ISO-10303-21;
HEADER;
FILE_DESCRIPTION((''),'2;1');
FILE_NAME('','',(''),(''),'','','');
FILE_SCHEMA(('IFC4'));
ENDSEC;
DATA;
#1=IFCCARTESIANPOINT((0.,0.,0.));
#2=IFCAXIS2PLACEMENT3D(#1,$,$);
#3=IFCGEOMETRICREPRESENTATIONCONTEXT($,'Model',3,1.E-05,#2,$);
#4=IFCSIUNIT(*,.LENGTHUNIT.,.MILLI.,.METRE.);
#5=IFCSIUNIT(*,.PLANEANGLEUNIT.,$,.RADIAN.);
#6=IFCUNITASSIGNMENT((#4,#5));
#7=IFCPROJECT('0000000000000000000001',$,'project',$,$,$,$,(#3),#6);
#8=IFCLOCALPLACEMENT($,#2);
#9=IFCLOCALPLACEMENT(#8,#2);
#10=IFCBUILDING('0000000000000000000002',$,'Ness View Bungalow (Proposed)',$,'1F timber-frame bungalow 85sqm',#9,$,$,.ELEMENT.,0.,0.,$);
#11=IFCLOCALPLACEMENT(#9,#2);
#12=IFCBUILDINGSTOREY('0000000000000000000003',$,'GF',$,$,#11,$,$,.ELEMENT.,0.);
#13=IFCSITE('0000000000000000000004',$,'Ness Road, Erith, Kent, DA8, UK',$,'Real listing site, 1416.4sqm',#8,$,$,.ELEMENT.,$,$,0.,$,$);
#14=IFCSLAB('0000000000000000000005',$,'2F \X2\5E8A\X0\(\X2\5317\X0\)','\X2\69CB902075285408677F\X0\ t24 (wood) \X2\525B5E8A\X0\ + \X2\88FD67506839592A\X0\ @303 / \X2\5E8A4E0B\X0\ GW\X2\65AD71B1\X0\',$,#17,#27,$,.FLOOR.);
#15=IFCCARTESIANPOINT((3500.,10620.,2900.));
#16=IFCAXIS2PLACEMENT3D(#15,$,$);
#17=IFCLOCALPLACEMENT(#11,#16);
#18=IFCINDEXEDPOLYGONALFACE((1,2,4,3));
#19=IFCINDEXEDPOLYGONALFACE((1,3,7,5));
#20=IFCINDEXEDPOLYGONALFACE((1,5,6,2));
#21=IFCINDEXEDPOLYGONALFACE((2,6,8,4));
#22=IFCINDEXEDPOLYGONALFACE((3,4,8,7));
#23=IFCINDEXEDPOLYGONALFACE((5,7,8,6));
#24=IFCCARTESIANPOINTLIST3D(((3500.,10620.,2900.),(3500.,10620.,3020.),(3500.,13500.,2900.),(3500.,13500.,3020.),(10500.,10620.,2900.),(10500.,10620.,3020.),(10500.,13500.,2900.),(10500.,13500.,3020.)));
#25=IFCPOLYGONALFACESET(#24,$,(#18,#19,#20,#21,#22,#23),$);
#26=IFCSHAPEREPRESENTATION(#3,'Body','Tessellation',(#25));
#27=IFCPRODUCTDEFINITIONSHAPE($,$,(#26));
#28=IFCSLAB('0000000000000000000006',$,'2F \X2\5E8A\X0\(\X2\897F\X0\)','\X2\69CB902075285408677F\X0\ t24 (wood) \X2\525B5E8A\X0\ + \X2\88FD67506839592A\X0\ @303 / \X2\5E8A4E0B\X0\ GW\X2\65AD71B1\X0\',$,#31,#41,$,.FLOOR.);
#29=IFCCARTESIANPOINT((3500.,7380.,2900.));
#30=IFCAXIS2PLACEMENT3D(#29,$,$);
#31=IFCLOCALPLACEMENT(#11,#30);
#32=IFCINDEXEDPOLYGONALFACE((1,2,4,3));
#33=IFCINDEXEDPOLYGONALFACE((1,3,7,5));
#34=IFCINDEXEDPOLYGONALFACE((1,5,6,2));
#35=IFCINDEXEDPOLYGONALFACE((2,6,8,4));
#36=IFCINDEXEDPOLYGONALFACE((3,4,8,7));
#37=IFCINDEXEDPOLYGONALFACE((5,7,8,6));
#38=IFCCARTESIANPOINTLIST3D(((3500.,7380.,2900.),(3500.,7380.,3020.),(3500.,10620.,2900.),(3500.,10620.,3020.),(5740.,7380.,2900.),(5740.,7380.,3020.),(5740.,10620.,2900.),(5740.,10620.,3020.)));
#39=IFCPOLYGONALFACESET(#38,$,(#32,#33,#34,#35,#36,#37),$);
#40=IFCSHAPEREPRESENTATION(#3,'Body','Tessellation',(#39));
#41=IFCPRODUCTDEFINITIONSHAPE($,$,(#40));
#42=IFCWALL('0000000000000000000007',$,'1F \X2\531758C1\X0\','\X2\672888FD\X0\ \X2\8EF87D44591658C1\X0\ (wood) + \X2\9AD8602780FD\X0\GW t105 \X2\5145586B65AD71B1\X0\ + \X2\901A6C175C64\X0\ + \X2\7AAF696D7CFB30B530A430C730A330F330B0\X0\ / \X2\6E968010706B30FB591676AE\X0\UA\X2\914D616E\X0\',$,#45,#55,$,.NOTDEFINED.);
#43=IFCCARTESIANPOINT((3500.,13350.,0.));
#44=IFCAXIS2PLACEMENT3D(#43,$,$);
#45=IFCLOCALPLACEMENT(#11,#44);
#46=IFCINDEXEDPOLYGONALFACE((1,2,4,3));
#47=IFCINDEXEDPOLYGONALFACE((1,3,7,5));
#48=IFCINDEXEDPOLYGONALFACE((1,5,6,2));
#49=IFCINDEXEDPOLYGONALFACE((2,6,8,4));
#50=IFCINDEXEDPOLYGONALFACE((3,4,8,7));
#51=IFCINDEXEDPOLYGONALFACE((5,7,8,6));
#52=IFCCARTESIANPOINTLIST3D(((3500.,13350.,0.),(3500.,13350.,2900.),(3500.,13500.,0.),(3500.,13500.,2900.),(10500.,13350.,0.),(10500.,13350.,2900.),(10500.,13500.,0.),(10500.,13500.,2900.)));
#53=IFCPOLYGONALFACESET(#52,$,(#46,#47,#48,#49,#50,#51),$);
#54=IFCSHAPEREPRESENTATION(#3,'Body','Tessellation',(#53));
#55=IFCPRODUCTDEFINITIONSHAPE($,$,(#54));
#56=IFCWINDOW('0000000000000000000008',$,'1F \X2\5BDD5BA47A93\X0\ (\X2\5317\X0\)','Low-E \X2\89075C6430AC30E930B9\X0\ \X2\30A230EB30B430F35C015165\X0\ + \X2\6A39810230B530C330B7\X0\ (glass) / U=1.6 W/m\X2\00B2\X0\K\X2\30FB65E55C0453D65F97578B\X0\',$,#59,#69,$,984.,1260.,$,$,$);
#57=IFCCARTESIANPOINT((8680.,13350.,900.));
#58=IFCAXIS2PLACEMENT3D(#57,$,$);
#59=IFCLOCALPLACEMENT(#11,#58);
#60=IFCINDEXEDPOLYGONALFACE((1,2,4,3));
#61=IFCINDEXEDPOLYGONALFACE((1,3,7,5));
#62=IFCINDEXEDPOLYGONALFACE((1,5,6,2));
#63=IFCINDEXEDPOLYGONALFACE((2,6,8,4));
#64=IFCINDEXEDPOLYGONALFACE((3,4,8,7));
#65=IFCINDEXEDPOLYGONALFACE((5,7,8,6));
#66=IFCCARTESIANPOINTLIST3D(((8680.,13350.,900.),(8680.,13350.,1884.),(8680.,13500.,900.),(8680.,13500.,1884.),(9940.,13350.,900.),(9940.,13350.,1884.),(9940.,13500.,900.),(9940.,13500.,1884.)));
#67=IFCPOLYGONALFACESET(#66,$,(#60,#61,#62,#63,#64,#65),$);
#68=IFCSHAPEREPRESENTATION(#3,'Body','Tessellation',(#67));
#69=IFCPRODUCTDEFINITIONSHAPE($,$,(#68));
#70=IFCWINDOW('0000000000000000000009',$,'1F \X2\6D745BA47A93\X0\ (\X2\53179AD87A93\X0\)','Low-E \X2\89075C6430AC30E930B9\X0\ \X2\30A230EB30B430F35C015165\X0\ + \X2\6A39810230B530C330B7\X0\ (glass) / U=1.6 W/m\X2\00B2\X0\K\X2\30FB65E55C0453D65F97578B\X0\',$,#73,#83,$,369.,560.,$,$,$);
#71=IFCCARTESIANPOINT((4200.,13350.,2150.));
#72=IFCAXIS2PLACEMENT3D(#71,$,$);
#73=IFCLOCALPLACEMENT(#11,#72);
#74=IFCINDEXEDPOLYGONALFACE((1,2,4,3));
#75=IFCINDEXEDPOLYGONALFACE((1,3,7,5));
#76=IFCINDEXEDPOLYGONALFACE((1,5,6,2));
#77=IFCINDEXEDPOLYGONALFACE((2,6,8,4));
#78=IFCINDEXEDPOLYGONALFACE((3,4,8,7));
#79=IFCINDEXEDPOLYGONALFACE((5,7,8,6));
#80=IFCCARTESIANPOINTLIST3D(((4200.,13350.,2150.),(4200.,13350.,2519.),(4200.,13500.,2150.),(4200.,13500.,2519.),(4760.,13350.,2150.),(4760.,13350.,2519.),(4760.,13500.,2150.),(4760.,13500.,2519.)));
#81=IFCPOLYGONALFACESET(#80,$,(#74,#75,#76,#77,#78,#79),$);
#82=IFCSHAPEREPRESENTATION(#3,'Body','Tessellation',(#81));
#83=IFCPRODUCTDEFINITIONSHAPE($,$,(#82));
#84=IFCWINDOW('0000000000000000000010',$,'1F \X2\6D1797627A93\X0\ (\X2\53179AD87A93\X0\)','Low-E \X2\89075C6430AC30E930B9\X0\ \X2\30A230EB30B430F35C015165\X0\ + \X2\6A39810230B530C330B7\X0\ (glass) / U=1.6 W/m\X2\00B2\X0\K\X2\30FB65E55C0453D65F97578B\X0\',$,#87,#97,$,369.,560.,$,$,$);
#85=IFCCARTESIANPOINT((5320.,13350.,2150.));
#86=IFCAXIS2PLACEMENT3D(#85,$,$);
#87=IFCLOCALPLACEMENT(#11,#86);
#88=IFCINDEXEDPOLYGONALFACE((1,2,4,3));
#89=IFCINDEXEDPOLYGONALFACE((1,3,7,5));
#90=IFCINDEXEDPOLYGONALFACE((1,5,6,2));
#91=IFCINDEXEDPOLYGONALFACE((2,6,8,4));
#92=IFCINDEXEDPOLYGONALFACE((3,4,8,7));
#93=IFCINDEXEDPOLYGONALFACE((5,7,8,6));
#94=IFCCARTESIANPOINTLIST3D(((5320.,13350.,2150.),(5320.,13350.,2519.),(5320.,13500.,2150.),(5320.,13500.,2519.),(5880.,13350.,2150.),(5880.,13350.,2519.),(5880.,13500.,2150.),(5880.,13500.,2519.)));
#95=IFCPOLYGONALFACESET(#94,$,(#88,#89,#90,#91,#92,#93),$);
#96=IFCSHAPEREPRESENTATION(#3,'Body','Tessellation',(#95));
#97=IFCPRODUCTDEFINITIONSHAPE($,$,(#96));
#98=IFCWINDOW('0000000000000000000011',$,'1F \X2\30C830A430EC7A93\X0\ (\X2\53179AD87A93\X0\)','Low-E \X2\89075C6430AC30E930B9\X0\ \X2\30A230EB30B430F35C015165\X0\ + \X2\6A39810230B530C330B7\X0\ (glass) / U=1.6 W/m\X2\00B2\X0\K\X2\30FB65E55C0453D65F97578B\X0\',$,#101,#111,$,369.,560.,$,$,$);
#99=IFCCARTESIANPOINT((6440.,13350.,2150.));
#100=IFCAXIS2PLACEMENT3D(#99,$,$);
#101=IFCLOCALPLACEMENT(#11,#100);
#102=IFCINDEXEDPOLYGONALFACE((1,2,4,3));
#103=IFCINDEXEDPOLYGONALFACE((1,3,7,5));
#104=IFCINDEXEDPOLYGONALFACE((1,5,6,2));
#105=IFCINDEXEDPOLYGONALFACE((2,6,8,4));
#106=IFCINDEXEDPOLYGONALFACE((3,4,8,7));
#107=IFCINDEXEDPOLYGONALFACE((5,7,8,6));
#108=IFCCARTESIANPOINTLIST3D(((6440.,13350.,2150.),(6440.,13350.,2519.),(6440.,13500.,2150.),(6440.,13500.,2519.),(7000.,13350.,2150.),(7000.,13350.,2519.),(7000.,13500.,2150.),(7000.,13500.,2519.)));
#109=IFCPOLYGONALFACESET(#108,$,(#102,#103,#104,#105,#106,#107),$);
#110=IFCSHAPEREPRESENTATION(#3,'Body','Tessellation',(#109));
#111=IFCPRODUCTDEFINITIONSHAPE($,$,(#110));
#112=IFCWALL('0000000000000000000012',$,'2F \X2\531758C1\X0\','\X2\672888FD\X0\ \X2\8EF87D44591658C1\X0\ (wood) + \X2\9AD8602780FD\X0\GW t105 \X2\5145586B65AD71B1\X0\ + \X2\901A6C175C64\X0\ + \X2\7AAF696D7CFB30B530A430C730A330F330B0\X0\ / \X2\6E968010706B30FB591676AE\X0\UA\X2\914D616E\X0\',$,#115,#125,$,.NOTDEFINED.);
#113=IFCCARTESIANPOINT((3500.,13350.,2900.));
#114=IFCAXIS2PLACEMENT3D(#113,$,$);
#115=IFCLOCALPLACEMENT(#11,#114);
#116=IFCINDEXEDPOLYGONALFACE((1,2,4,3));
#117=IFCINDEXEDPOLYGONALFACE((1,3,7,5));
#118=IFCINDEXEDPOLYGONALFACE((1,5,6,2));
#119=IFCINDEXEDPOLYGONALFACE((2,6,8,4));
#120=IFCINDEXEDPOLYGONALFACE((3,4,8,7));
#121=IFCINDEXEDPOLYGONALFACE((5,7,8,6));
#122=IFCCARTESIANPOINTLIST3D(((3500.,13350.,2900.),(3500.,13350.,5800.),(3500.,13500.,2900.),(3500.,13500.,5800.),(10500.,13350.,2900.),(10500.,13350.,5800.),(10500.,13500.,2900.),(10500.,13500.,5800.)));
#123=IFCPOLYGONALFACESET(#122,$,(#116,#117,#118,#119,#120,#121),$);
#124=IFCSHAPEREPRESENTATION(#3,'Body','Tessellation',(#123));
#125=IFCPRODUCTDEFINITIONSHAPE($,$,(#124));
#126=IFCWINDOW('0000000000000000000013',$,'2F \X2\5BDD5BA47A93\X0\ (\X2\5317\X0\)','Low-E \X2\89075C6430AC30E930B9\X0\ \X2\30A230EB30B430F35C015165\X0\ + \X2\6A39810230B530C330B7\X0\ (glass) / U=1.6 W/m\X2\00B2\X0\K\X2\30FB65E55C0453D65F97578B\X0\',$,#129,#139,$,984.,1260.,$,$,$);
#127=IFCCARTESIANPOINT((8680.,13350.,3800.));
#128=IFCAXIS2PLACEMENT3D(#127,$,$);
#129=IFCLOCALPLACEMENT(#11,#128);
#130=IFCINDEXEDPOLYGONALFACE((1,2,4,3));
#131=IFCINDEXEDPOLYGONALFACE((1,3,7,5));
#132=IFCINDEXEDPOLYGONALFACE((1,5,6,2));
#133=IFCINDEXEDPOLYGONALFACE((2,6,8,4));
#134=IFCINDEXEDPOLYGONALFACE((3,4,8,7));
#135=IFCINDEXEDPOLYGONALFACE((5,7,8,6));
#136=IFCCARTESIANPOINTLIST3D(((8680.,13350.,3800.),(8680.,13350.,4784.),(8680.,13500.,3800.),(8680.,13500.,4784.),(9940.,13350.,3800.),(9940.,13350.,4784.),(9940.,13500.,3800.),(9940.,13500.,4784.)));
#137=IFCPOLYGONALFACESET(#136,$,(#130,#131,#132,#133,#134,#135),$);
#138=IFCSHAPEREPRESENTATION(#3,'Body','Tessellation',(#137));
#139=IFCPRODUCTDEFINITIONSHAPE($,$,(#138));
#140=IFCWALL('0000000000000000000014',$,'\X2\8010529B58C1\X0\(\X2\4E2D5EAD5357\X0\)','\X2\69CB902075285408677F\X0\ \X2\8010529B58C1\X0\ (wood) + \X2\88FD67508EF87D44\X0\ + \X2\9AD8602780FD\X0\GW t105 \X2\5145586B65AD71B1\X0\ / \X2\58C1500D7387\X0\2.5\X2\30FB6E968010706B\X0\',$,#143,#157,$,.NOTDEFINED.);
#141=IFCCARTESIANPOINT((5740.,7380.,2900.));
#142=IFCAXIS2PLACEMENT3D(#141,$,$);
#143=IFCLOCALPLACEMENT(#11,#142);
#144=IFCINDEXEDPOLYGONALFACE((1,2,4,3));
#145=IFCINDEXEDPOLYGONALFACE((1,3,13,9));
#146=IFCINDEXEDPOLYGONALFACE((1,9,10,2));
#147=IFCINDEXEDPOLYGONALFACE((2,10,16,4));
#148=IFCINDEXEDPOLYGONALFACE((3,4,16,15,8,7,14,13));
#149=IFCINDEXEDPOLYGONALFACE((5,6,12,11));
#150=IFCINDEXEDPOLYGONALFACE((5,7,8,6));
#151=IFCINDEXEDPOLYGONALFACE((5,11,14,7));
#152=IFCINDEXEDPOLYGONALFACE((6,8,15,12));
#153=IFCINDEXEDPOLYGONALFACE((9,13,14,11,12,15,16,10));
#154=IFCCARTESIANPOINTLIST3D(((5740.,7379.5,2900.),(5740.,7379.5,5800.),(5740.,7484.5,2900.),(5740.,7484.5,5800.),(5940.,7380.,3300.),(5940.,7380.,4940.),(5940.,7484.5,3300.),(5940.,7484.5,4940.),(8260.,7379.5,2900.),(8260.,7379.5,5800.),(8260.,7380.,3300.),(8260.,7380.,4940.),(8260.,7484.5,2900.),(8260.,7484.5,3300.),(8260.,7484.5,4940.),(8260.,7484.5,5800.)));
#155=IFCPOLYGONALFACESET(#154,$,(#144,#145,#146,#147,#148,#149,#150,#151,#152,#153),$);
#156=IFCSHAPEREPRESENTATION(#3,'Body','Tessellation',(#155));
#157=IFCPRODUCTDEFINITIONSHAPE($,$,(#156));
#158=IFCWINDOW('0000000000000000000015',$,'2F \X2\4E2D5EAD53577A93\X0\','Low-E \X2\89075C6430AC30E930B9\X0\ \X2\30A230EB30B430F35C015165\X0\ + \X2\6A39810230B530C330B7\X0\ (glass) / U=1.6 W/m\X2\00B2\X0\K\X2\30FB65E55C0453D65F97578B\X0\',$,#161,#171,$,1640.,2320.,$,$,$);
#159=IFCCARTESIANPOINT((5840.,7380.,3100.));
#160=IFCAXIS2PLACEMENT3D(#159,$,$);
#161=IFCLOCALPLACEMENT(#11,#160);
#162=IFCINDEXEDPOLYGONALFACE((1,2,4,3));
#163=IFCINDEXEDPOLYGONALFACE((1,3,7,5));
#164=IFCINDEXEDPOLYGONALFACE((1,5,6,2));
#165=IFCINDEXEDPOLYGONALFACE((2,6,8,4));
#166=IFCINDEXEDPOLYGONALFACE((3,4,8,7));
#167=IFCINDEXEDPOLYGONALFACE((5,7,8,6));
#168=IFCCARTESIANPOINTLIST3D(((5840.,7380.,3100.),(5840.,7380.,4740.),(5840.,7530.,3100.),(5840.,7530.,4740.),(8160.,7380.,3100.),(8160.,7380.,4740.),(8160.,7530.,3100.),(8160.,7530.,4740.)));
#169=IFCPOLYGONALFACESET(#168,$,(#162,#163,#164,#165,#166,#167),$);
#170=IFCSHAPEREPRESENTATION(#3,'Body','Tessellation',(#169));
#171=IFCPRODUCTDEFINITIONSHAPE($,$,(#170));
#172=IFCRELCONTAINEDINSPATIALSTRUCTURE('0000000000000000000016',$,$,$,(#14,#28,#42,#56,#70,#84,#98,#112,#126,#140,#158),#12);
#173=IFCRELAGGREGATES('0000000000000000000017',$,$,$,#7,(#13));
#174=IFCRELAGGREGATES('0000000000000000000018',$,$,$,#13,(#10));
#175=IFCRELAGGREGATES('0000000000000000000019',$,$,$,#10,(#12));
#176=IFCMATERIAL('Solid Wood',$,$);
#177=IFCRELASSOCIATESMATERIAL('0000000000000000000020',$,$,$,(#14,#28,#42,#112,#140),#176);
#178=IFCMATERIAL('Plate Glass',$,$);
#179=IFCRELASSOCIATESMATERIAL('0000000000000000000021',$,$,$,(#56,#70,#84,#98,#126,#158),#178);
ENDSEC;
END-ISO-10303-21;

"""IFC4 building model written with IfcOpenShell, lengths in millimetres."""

from ifc_helpers import new_model, si_unit, frame, frame_2d, origin, place, context, project, spatial, rectangle, extrude, material, element, fill, save


model = new_model("IFC4")

# Units and contexts
model_context = context("Model", 3, precision=1e-05, world=origin())
ifc_project = project(units=[si_unit("LENGTHUNIT", "METRE", prefix="MILLI"), si_unit("PLANEANGLEUNIT", "RADIAN")], contexts=[model_context])

# Site, building, storey
site_placement = place(None, origin())
site = spatial("IfcSite", under=ifc_project, at=site_placement, Name="Ness Road, Erith, Kent, DA8, UK", ObjectType="Real listing site, 1416.4sqm", CompositionType="ELEMENT", RefElevation=0.0)
building_placement = place(site_placement, origin())
building = spatial("IfcBuilding", under=site, at=building_placement, Name="Ness View Bungalow (Proposed)", ObjectType="1F timber-frame bungalow 85sqm", CompositionType="ELEMENT", ElevationOfRefHeight=0.0, ElevationOfTerrain=0.0)
storey_placement = place(building_placement, origin())
storey = spatial("IfcBuildingStorey", under=building, at=storey_placement, Name="GF", CompositionType="ELEMENT", Elevation=0.0)

# Slabs
ifc_material_1 = material(Name="Solid Wood")
slab_1_placement = place(storey_placement, frame((3500.0, 10620.0, 2900.0)))
element("IfcSlab", 1, at=slab_1_placement, inside=storey, material=ifc_material_1, Name="2F 床(北)", Description="構造用合板 t24 (wood) 剛床 + 製材根太 @303 / 床下 GW断熱", PredefinedType="FLOOR", context=model_context, shape_type="SweptSolid", body=[
    extrude(rectangle(XDim=7000.0, YDim=2880.0, at=frame_2d((3500.0, 1440.0))), frame((3500.0, 10620.0, 2900.0)), (0.0, 0.0, 1.0), 120.0),
])
slab_2_placement = place(storey_placement, frame((3500.0, 7380.0, 2900.0)))
element("IfcSlab", 2, at=slab_2_placement, inside=storey, material=ifc_material_1, Name="2F 床(西)", Description="構造用合板 t24 (wood) 剛床 + 製材根太 @303 / 床下 GW断熱", PredefinedType="FLOOR", context=model_context, shape_type="SweptSolid", body=[
    extrude(rectangle(XDim=2240.0, YDim=3240.0, at=frame_2d((1120.0, 1620.0))), frame((3500.0, 7380.0, 2900.0)), (0.0, 0.0, 1.0), 120.0),
])

# Wall, openings, windows
wall_1_placement = place(storey_placement, frame((3500.0, 13350.0, 0.0)))
wall_1 = element("IfcWall", 3, at=wall_1_placement, inside=storey, material=ifc_material_1, Name="1F 北壁", Description="木製 軸組外壁 (wood) + 高性能GW t105 充填断熱 + 通気層 + 窯業系サイディング / 準耐火・外皮UA配慮", PredefinedType="NOTDEFINED", context=model_context, shape_type="SweptSolid", body=[
    extrude(rectangle(XDim=7000.0, YDim=150.0, at=frame_2d((3500.0, 75.0))), frame((3500.0, 13350.0, 0.0)), (0.0, 0.0, 1.0), 2900.0),
])
opening_1_placement = place(storey_placement, frame((8680.0, 13350.0, 900.0)))
opening_1 = element("IfcOpeningElement", 4, at=opening_1_placement, cuts=wall_1, PredefinedType="NOTDEFINED", context=model_context, shape_type="SweptSolid", body=[
    extrude(rectangle(XDim=1260.0, YDim=150.0, at=frame_2d((630.0, 75.0))), frame((8680.0, 13350.0, 900.0)), (0.0, 0.0, 1.0), 984.0),
])
opening_2_placement = place(storey_placement, frame((4200.0, 13350.0, 2150.0)))
opening_2 = element("IfcOpeningElement", 5, at=opening_2_placement, cuts=wall_1, PredefinedType="NOTDEFINED", context=model_context, shape_type="SweptSolid", body=[
    extrude(rectangle(XDim=560.0, YDim=150.0, at=frame_2d((280.0, 75.0))), frame((4200.0, 13350.0, 2150.0)), (0.0, 0.0, 1.0), 369.0),
])
opening_3_placement = place(storey_placement, frame((5320.0, 13350.0, 2150.0)))
opening_3 = element("IfcOpeningElement", 6, at=opening_3_placement, cuts=wall_1, PredefinedType="NOTDEFINED", context=model_context, shape_type="SweptSolid", body=[
    extrude(rectangle(XDim=560.0, YDim=150.0, at=frame_2d((280.0, 75.0))), frame((5320.0, 13350.0, 2150.0)), (0.0, 0.0, 1.0), 369.0),
])
opening_4_placement = place(storey_placement, frame((6440.0, 13350.0, 2150.0)))
opening_4 = element("IfcOpeningElement", 7, at=opening_4_placement, cuts=wall_1, PredefinedType="NOTDEFINED", context=model_context, shape_type="SweptSolid", body=[
    extrude(rectangle(XDim=560.0, YDim=150.0, at=frame_2d((280.0, 75.0))), frame((6440.0, 13350.0, 2150.0)), (0.0, 0.0, 1.0), 369.0),
])
ifc_material_2 = material(Name="Plate Glass")
window_1_placement = place(storey_placement, frame((8680.0, 13350.0, 900.0)))
window_1 = element("IfcWindow", 8, at=window_1_placement, inside=storey, material=ifc_material_2, Name="1F 寝室窓 (北)", Description="Low-E 複層ガラス アルゴン封入 + 樹脂サッシ (glass) / U=1.6 W/m²K・日射取得型", OverallHeight=984.0, OverallWidth=1260.0, context=model_context, shape_type="SweptSolid", body=[
    extrude(rectangle(XDim=1260.0, YDim=150.0, at=frame_2d((630.0, 75.0))), frame((8680.0, 13350.0, 900.0)), (0.0, 0.0, 1.0), 984.0),
])
fill(opening_1, window_1)
window_2_placement = place(storey_placement, frame((4200.0, 13350.0, 2150.0)))
window_2 = element("IfcWindow", 9, at=window_2_placement, inside=storey, material=ifc_material_2, Name="1F 浴室窓 (北高窓)", Description="Low-E 複層ガラス アルゴン封入 + 樹脂サッシ (glass) / U=1.6 W/m²K・日射取得型", OverallHeight=369.0, OverallWidth=560.0, context=model_context, shape_type="SweptSolid", body=[
    extrude(rectangle(XDim=560.0, YDim=150.0, at=frame_2d((280.0, 75.0))), frame((4200.0, 13350.0, 2150.0)), (0.0, 0.0, 1.0), 369.0),
])
fill(opening_2, window_2)
window_3_placement = place(storey_placement, frame((5320.0, 13350.0, 2150.0)))
window_3 = element("IfcWindow", 10, at=window_3_placement, inside=storey, material=ifc_material_2, Name="1F 洗面窓 (北高窓)", Description="Low-E 複層ガラス アルゴン封入 + 樹脂サッシ (glass) / U=1.6 W/m²K・日射取得型", OverallHeight=369.0, OverallWidth=560.0, context=model_context, shape_type="SweptSolid", body=[
    extrude(rectangle(XDim=560.0, YDim=150.0, at=frame_2d((280.0, 75.0))), frame((5320.0, 13350.0, 2150.0)), (0.0, 0.0, 1.0), 369.0),
])
fill(opening_3, window_3)
window_4_placement = place(storey_placement, frame((6440.0, 13350.0, 2150.0)))
window_4 = element("IfcWindow", 11, at=window_4_placement, inside=storey, material=ifc_material_2, Name="1F トイレ窓 (北高窓)", Description="Low-E 複層ガラス アルゴン封入 + 樹脂サッシ (glass) / U=1.6 W/m²K・日射取得型", OverallHeight=369.0, OverallWidth=560.0, context=model_context, shape_type="SweptSolid", body=[
    extrude(rectangle(XDim=560.0, YDim=150.0, at=frame_2d((280.0, 75.0))), frame((6440.0, 13350.0, 2150.0)), (0.0, 0.0, 1.0), 369.0),
])
fill(opening_4, window_4)

# Walls, openings, windows
wall_2_placement = place(storey_placement, frame((3500.0, 13350.0, 2900.0)))
wall_2 = element("IfcWall", 12, at=wall_2_placement, inside=storey, material=ifc_material_1, Name="2F 北壁", Description="木製 軸組外壁 (wood) + 高性能GW t105 充填断熱 + 通気層 + 窯業系サイディング / 準耐火・外皮UA配慮", PredefinedType="NOTDEFINED", context=model_context, shape_type="SweptSolid", body=[
    extrude(rectangle(XDim=7000.0, YDim=150.0, at=frame_2d((3500.0, 75.0))), frame((3500.0, 13350.0, 2900.0)), (0.0, 0.0, 1.0), 2900.0),
])
opening_5_placement = place(storey_placement, frame((8680.0, 13350.0, 3800.0)))
opening_5 = element("IfcOpeningElement", 13, at=opening_5_placement, cuts=wall_2, PredefinedType="NOTDEFINED", context=model_context, shape_type="SweptSolid", body=[
    extrude(rectangle(XDim=1260.0, YDim=150.0, at=frame_2d((630.0, 75.0))), frame((8680.0, 13350.0, 3800.0)), (0.0, 0.0, 1.0), 984.0),
])
window_5_placement = place(storey_placement, frame((8680.0, 13350.0, 3800.0)))
window_5 = element("IfcWindow", 14, at=window_5_placement, inside=storey, material=ifc_material_2, Name="2F 寝室窓 (北)", Description="Low-E 複層ガラス アルゴン封入 + 樹脂サッシ (glass) / U=1.6 W/m²K・日射取得型", OverallHeight=984.0, OverallWidth=1260.0, context=model_context, shape_type="SweptSolid", body=[
    extrude(rectangle(XDim=1260.0, YDim=150.0, at=frame_2d((630.0, 75.0))), frame((8680.0, 13350.0, 3800.0)), (0.0, 0.0, 1.0), 984.0),
])
fill(opening_5, window_5)
wall_3_placement = place(storey_placement, frame((5740.0, 7380.0, 2900.0)))
wall_3 = element("IfcWall", 15, at=wall_3_placement, inside=storey, material=ifc_material_1, Name="耐力壁(中庭南)", Description="構造用合板 耐力壁 (wood) + 製材軸組 + 高性能GW t105 充填断熱 / 壁倍率2.5・準耐火", PredefinedType="NOTDEFINED", context=model_context, shape_type="SweptSolid", body=[
    extrude(rectangle(XDim=2520.0, YDim=105.0, at=frame_2d((1260.0, 52.0))), frame((5740.0, 7380.0, 2900.0)), (0.0, 0.0, 1.0), 2900.0),
])
opening_6_placement = place(storey_placement, frame((5840.0, 7380.0, 3100.0)))
opening_6 = element("IfcOpeningElement", 16, at=opening_6_placement, cuts=wall_3, PredefinedType="NOTDEFINED", context=model_context, shape_type="SweptSolid", body=[
    extrude(rectangle(XDim=2320.0, YDim=150.0, at=frame_2d((1160.0, 75.0))), frame((5840.0, 7380.0, 3100.0)), (0.0, 0.0, 1.0), 1640.0),
])
window_6_placement = place(storey_placement, frame((5840.0, 7380.0, 3100.0)))
window_6 = element("IfcWindow", 17, at=window_6_placement, inside=storey, material=ifc_material_2, Name="2F 中庭南窓", Description="Low-E 複層ガラス アルゴン封入 + 樹脂サッシ (glass) / U=1.6 W/m²K・日射取得型", OverallHeight=1640.0, OverallWidth=2320.0, context=model_context, shape_type="SweptSolid", body=[
    extrude(rectangle(XDim=2320.0, YDim=150.0, at=frame_2d((1160.0, 75.0))), frame((5840.0, 7380.0, 3100.0)), (0.0, 0.0, 1.0), 1640.0),
])
fill(opening_6, window_6)

save(model, "model.ifc")
